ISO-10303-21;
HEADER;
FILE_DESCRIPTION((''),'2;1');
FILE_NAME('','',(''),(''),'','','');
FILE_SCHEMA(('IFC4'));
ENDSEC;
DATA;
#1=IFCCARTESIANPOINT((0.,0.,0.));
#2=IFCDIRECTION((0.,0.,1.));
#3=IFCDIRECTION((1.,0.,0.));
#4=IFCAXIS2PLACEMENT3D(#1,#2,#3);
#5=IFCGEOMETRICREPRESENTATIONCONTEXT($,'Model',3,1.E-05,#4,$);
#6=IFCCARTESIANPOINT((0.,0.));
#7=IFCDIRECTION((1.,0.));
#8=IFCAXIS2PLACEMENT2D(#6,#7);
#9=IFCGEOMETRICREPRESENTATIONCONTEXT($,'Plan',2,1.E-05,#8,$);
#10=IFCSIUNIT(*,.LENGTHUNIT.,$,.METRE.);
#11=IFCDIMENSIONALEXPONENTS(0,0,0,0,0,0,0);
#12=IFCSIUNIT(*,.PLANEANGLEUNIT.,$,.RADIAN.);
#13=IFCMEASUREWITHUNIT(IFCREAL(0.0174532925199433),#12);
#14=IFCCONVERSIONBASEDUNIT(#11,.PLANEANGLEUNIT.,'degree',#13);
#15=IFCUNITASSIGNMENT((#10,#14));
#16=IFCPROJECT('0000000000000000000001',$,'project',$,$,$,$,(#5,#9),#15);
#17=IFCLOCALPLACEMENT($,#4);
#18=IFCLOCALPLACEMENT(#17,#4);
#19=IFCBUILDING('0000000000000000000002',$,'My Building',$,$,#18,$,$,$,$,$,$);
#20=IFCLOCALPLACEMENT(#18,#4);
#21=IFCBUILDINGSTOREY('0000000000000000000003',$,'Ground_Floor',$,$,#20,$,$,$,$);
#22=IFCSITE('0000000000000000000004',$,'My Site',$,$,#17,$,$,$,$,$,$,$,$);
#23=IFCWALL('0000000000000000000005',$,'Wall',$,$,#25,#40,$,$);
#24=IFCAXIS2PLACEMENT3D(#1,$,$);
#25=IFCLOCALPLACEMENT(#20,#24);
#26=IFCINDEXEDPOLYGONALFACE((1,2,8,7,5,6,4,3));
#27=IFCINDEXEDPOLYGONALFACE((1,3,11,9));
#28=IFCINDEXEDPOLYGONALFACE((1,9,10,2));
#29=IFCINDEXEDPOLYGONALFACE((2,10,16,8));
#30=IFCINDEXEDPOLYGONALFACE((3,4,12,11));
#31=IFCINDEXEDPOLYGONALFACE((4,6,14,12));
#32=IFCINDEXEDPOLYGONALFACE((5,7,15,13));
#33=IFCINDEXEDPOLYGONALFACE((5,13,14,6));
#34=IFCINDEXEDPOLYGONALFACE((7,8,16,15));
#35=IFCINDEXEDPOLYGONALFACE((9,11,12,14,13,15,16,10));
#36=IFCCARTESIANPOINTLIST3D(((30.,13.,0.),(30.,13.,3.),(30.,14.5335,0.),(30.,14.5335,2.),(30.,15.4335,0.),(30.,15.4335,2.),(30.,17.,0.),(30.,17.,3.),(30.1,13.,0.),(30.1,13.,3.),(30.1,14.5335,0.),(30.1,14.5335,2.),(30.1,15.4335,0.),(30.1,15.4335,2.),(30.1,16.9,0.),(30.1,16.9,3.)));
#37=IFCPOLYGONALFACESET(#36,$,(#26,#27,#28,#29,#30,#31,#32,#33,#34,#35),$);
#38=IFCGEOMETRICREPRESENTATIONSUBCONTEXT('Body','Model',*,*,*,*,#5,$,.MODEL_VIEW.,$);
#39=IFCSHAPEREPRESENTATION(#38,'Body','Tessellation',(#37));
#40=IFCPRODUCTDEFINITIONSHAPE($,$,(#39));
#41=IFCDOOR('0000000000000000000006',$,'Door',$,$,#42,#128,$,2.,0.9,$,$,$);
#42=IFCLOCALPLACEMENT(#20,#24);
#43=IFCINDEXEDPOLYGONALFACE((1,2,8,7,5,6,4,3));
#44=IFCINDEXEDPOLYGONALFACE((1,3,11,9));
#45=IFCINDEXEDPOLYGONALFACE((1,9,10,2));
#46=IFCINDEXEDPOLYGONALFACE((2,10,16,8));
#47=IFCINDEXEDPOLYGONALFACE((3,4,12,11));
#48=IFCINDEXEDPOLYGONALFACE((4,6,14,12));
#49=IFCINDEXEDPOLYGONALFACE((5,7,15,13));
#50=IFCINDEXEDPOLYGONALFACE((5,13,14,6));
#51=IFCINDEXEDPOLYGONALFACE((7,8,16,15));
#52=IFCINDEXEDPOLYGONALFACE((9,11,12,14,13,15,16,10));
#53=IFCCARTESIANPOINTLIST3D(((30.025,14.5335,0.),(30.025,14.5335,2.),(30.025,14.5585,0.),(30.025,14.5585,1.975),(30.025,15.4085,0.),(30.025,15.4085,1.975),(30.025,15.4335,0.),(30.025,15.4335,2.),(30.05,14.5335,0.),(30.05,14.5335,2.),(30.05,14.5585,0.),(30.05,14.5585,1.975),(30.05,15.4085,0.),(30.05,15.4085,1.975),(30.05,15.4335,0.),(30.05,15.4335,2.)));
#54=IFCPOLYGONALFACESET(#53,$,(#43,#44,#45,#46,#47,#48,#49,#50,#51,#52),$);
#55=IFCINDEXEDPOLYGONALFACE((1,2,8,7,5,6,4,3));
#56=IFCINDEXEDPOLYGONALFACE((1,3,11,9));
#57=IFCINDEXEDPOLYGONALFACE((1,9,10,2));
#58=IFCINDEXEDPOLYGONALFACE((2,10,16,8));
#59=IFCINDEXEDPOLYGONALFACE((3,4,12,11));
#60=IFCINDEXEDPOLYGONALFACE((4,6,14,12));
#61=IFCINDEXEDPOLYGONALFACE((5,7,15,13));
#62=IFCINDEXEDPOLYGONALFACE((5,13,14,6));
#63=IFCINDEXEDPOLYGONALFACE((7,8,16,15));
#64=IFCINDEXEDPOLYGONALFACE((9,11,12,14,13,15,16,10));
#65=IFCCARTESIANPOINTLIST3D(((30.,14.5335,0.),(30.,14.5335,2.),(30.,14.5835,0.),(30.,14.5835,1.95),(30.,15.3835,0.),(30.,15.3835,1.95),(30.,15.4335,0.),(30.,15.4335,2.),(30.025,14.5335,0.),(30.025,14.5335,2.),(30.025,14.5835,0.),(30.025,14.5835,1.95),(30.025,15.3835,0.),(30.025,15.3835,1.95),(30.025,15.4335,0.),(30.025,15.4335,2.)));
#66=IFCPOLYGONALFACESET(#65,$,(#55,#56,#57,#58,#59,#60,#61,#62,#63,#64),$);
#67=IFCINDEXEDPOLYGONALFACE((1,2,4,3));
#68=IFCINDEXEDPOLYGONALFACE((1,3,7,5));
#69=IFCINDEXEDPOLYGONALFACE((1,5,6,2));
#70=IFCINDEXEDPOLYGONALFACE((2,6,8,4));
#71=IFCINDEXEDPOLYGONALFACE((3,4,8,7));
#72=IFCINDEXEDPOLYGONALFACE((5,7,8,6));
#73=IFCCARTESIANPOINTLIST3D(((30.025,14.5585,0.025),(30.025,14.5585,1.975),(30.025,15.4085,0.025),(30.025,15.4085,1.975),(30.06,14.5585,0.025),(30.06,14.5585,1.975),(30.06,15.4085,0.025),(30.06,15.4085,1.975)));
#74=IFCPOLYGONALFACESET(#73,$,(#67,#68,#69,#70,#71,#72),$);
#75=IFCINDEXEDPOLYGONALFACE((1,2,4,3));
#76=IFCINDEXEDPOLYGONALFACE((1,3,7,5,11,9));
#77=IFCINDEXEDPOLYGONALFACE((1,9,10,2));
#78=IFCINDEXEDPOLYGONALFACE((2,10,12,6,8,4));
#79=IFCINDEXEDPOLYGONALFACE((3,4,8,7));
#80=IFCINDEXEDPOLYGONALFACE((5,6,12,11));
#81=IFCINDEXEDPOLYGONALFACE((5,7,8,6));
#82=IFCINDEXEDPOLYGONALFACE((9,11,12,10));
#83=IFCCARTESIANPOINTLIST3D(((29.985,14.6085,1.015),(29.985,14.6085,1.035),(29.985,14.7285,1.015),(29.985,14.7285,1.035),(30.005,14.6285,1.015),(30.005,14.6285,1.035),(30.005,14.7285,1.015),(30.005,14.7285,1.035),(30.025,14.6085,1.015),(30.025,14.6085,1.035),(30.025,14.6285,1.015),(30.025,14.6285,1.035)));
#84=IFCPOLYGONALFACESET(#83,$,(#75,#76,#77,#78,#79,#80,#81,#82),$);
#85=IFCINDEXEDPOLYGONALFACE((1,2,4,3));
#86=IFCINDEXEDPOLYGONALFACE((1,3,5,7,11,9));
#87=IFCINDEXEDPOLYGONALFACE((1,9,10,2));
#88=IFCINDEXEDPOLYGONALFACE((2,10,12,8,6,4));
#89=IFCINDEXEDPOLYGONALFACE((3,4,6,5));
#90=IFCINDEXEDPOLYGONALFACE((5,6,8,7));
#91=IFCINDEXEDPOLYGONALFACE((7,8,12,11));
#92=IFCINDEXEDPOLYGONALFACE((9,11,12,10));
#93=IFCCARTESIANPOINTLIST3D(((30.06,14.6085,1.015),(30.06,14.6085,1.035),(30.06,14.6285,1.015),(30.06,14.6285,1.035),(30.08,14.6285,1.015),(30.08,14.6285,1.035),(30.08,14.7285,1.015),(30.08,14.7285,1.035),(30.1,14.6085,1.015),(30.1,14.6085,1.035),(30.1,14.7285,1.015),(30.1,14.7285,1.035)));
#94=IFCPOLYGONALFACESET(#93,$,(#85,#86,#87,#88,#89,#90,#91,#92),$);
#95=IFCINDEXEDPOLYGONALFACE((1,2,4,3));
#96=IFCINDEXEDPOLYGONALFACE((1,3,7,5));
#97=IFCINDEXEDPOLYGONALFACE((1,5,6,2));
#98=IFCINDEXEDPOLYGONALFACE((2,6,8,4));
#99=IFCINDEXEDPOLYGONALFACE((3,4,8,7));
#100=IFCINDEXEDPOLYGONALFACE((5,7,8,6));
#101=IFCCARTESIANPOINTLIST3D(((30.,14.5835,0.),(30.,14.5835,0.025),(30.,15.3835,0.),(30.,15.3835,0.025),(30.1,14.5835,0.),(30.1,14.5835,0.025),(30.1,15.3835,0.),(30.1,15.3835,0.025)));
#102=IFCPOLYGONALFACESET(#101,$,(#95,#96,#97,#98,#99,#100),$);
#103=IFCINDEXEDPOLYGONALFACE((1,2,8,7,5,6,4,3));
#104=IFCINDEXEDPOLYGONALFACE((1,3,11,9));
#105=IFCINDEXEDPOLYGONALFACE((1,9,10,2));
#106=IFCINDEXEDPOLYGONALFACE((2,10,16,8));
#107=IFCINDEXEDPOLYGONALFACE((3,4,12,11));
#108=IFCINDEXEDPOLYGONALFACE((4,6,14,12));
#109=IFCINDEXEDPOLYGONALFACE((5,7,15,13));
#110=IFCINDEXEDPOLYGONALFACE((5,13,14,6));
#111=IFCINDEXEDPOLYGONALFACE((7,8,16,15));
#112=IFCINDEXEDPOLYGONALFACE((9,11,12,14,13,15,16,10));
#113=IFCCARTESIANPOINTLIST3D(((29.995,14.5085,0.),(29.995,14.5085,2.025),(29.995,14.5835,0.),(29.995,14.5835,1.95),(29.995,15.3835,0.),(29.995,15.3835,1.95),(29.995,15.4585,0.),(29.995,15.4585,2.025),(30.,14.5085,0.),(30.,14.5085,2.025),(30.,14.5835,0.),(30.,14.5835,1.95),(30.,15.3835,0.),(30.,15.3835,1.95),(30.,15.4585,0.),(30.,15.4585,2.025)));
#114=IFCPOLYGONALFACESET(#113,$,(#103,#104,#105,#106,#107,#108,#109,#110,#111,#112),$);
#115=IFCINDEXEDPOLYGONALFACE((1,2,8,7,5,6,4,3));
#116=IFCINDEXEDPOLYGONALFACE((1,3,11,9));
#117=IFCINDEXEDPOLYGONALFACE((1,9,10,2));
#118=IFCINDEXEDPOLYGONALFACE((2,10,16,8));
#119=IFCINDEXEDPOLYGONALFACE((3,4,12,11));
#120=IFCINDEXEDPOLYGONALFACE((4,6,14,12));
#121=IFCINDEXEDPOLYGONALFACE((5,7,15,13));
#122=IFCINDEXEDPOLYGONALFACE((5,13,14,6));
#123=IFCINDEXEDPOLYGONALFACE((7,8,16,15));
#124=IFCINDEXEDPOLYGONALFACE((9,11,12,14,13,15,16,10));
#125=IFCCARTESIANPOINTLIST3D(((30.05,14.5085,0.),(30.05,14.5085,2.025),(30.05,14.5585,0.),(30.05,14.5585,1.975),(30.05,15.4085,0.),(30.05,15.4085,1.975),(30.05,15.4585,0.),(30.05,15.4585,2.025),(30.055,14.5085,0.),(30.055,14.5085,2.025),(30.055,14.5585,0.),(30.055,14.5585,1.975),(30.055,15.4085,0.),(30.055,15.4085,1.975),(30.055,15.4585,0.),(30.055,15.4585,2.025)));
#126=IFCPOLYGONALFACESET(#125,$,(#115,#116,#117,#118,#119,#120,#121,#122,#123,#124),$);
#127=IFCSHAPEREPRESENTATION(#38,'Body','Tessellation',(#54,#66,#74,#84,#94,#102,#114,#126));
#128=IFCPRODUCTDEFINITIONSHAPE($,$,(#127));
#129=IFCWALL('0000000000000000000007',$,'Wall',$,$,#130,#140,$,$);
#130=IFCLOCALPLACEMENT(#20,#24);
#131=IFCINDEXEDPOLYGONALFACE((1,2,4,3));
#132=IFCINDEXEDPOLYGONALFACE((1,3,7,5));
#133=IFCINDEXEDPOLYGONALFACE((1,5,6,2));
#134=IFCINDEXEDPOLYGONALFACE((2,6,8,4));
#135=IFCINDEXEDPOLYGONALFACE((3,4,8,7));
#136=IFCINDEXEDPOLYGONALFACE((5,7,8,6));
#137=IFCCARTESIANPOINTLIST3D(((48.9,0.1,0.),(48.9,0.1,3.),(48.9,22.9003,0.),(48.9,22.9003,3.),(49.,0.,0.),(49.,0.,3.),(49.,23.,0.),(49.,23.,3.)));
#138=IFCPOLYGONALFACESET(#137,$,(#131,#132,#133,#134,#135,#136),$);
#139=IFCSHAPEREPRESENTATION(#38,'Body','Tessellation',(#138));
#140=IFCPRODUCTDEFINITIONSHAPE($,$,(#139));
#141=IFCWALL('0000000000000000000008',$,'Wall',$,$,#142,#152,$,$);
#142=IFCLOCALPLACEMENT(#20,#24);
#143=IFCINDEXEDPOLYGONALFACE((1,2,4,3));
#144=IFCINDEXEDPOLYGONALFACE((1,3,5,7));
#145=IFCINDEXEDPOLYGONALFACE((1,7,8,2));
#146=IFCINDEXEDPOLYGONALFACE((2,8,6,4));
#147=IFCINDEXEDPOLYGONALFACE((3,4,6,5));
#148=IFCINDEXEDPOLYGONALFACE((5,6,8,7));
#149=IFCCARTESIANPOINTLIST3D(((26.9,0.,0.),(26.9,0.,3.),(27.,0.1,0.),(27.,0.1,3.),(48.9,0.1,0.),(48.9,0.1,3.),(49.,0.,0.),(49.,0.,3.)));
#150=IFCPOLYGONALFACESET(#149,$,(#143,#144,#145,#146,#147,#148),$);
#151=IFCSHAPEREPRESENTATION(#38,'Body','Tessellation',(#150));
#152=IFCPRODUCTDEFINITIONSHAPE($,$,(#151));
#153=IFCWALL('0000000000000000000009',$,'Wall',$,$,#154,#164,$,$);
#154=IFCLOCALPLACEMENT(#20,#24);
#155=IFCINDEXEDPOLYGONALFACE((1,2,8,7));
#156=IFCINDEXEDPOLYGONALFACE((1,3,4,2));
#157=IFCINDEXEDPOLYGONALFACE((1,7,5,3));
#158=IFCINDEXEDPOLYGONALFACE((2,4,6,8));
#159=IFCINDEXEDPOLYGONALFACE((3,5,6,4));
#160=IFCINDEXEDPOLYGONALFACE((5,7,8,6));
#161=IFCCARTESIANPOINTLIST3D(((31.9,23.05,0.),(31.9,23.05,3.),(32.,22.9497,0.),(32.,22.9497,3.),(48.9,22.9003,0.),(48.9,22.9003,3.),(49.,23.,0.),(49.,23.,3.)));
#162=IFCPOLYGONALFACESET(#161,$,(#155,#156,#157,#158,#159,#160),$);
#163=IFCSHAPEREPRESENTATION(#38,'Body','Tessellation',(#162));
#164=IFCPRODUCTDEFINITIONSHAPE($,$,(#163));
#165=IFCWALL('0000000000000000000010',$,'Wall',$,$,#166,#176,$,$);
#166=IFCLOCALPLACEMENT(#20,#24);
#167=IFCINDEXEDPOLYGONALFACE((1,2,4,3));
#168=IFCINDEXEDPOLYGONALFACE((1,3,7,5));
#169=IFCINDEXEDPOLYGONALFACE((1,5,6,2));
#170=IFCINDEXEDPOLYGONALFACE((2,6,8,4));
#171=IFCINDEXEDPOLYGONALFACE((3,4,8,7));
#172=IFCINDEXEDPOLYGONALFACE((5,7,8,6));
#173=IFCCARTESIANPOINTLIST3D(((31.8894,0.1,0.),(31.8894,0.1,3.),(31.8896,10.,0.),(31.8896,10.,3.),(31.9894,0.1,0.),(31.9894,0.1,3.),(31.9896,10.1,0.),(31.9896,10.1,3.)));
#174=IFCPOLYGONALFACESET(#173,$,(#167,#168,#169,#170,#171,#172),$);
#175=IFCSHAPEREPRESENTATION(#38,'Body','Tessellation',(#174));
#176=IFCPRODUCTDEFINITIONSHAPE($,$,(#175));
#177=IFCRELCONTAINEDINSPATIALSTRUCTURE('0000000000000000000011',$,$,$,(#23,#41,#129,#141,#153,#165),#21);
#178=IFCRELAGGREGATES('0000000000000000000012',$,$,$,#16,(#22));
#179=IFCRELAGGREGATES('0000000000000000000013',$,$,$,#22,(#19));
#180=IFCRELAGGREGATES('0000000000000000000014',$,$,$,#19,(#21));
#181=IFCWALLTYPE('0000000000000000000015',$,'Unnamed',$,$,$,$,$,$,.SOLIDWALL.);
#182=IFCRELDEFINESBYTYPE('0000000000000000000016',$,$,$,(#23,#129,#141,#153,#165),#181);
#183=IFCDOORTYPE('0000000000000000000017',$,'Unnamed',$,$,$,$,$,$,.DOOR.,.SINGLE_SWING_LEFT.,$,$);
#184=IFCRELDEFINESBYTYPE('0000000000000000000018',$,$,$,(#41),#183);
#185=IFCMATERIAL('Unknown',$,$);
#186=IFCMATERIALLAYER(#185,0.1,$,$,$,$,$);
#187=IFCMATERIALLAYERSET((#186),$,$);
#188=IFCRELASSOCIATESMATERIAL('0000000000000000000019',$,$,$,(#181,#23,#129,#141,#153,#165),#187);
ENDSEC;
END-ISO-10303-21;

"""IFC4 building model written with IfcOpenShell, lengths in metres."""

from ifc_helpers import new_model, entity, si_unit, converted_unit, frame, origin_with_axes, origin_2d_with_axis, place, context, subcontext, project, spatial, line, indexed_curve, outline, extrude, shape, source, transform, mapped, material, layer, layer_set, layer_usage, type_object, type_shapes, element, fill, save


model = new_model("IFC4")

# Units and contexts
model_context = context("Model", 3, precision=1e-05, world=origin_with_axes())
plan_context = context("Plan", 2, precision=1e-05, world=origin_2d_with_axis())
body_context_1 = subcontext(model_context, "Body", "Model", "MODEL_VIEW")
body_context_2 = subcontext(plan_context, "Body", "Plan", "PLAN_VIEW")
ifc_project = project(units=[si_unit("LENGTHUNIT", "METRE"), converted_unit("PLANEANGLEUNIT", "degree", entity("IfcReal", 0.0174532925199433), si_unit("PLANEANGLEUNIT", "RADIAN"), dimensions=[0, 0, 0, 0, 0, 0, 0])], contexts=[model_context, plan_context])

# Site, building, storey
site_placement = place(None, origin_with_axes())
site = spatial("IfcSite", under=ifc_project, at=site_placement, Name="My Site")
building_placement = place(site_placement, origin_with_axes())
building = spatial("IfcBuilding", under=site, at=building_placement, Name="My Building")
storey_placement = place(building_placement, origin_with_axes())
storey = spatial("IfcBuildingStorey", under=building, at=storey_placement, Name="Ground_Floor")

# Shared definitions
ifc_material = material(Name="Unknown")
ifc_layer = layer(ifc_material, 0.1)
ifc_layer_set = layer_set([ifc_layer])
wall_type = type_object("IfcWallType", Name="Unnamed", PredefinedType="SOLIDWALL", material=ifc_layer_set)

# Shared definitions
shared_shape_1 = source(origin_with_axes(), body_context_1, "Body", "SweptSolid", [
    extrude(outline(indexed_curve([(0.0, 0.0), (0.9, 0.0), (0.9, 2.0), (0.0, 2.0)], segments=[line(1, 2, 3, 4, 1)])), frame((0.0, -0.6, 0.0), z_axis=(0.0, -1.0, 0.0), x_axis=(1.0, 0.0, 0.0)), (0.0, 0.0, -1.0), 1.2),
])
door_type_1 = type_object("IfcDoorType", Name="Unnamed", OperationType="SINGLE_SWING_LEFT", PredefinedType="DOOR")
shared_shape_2 = source(origin_with_axes(), body_context_1, "Body", "SweptSolid", [
    extrude(outline(indexed_curve([(0.0, 0.0), (0.0, 2.0), (0.9, 2.0), (0.9, 0.0), (0.875, 0.0), (0.875, 1.975), (0.025, 1.975), (0.025, 0.0)], segments=[line(1, 2, 3, 4, 5, 6, 7, 8, 1)])), frame((0.0, 0.025, 0.0), z_axis=(0.0, -1.0, 0.0), x_axis=(1.0, 0.0, 0.0)), (0.0, 0.0, -1.0), 0.025),
    extrude(outline(indexed_curve([(0.0, 0.0), (0.0, 2.0), (0.9, 2.0), (0.9, 0.0), (0.85, 0.0), (0.85, 1.95), (0.05, 1.95), (0.05, 0.0)], segments=[line(1, 2, 3, 4, 5, 6, 7, 8, 1)])), frame((0.0, 0.0, 0.0), z_axis=(0.0, -1.0, 0.0), x_axis=(1.0, 0.0, 0.0)), (0.0, 0.0, -1.0), 0.025),
    extrude(outline(indexed_curve([(0.0, 0.0), (0.85, 0.0), (0.85, 0.035), (0.0, 0.035)], segments=[line(1, 2, 3, 4, 1)])), frame((0.025, 0.025, 0.025), z_axis=(0.0, 0.0, 1.0), x_axis=(1.0, 0.0, 0.0)), (0.0, 0.0, 1.0), 1.95),
    extrude(outline(indexed_curve([(0.0, 0.0), (0.0, -0.04), (-0.12, -0.04), (-0.12, -0.02), (-0.02, -0.02), (-0.02, 0.0)], segments=[line(1, 2, 3, 4, 5, 6, 1)])), frame((0.825, 0.025, 1.015), z_axis=(0.0, 0.0, 1.0), x_axis=(1.0, 0.0, 0.0)), (0.0, 0.0, 1.0), 0.02),
    extrude(outline(indexed_curve([(0.0, 0.0), (0.0, 0.04), (-0.12, 0.04), (-0.12, 0.02), (-0.02, 0.02), (-0.02, 0.0)], segments=[line(1, 2, 3, 4, 5, 6, 1)])), frame((0.825, 0.06, 1.015), z_axis=(0.0, 0.0, 1.0), x_axis=(1.0, 0.0, 0.0)), (0.0, 0.0, 1.0), 0.02),
    extrude(outline(indexed_curve([(0.0, 0.0), (0.8, 0.0), (0.8, 0.1), (0.0, 0.1)], segments=[line(1, 2, 3, 4, 1)])), frame((0.05, 0.0, 0.0), z_axis=(0.0, 0.0, 1.0), x_axis=(1.0, 0.0, 0.0)), (0.0, 0.0, 1.0), 0.025),
    extrude(outline(indexed_curve([(0.0, 0.0), (0.0, 2.025), (0.95, 2.025), (0.95, 0.0), (0.875, 0.0), (0.875, 1.95), (0.075, 1.95), (0.075, 0.0)], segments=[line(1, 2, 3, 4, 5, 6, 7, 8, 1)])), frame((-0.025, -0.005, 0.0), z_axis=(0.0, -1.0, 0.0), x_axis=(1.0, 0.0, 0.0)), (0.0, 0.0, -1.0), 0.005),
    extrude(outline(indexed_curve([(0.0, 0.0), (0.0, 2.025), (0.95, 2.025), (0.95, 0.0), (0.9, 0.0), (0.9, 1.975), (0.05, 1.975), (0.05, 0.0)], segments=[line(1, 2, 3, 4, 5, 6, 7, 8, 1)])), frame((-0.025, 0.05, 0.0), z_axis=(0.0, -1.0, 0.0), x_axis=(1.0, 0.0, 0.0)), (0.0, 0.0, -1.0), 0.005),
])
shared_shape_3 = source(origin_with_axes(), body_context_2, "Body", "Curve2D", [
    entity("IfcIndexedPolyCurve", entity("IfcCartesianPointList2D", [[0.0, 0.0], [0.0, 0.05], [0.025, 0.05], [0.025, 0.025], [0.05, 0.025], [0.05, 0.0]]), [entity("IfcLineIndex", [1, 2, 3, 4, 5, 6, 1])]),
    entity("IfcIndexedPolyCurve", entity("IfcCartesianPointList2D", [[0.9, 0.0], [0.9, 0.05], [0.875, 0.05], [0.875, 0.025], [0.85, 0.025], [0.85, 0.0]]), [entity("IfcLineIndex", [1, 2, 3, 4, 5, 6, 1])]),
    entity("IfcTrimmedCurve", entity("IfcEllipse", entity("IfcAxis2Placement2D", entity("IfcCartesianPoint", [0.06, 0.05]), entity("IfcDirection", [1.0, 0.0])), 0.815, 0.85), [entity("IfcCartesianPoint", [0.875, 0.05])], [entity("IfcCartesianPoint", [0.06, 0.9])], True, "CARTESIAN"),
    entity("IfcIndexedPolyCurve", entity("IfcCartesianPointList2D", [[0.025, 0.05], [0.06, 0.05], [0.06, 0.9], [0.025, 0.9]]), [entity("IfcLineIndex", [1, 2, 3, 4, 1])]),
])
type_shapes(door_type_1, [shared_shape_2, shared_shape_3])

# Wall, opening, door
ifc_layer_usage_1 = layer_usage(ifc_layer_set, "AXIS2", "POSITIVE", 0.0)
wall_1_placement = place(storey_placement, frame((30.0, 17.0, 0.0), z_axis=(0.0, 0.0, 1.0), x_axis=(0.0, -1.0, 0.0)))
wall_1 = element("IfcWall", 1, at=wall_1_placement, inside=storey, type_object=wall_type, material=ifc_layer_usage_1, Name="Wall", context=body_context_1, shape_type="SweptSolid", body=[
    extrude(outline(indexed_curve([(0.0, 0.0), (0.1, 0.1), (4.0, 0.1), (4.0, 0.0)], segments=[line(1, 2, 3, 4, 1)])), origin_with_axes(), (0.0, 0.0, 1.0), 3.0),
])
opening_1_placement = place(wall_1_placement, frame((1.5665, 0.0, 0.0), z_axis=(0.0, 0.0, 1.0), x_axis=(1.0, 0.0, 0.0)))
opening_1 = element("IfcOpeningElement", 2, at=opening_1_placement, cuts=wall_1, PredefinedType="OPENING", context=body_context_1, shape_type="MappedRepresentation", body=[
    mapped(shared_shape_1, transform((0.0, 0.0, 0.0), x_axis=(1.0, 0.0, 0.0), y_axis=(0.0, 1.0, 0.0), z_axis=(0.0, 0.0, 1.0), scale=1.0)),
])
door_1_placement = place(opening_1_placement, origin_with_axes())
door_1 = element("IfcDoor", 3, at=door_1_placement, inside=storey, type_object=door_type_1, Name="Door", OverallHeight=2.0, OverallWidth=0.9, shapes=[
    shape(body_context_1, "Body", "MappedRepresentation", [mapped(shared_shape_2, transform((0.0, 0.0, 0.0), x_axis=(1.0, 0.0, 0.0), y_axis=(0.0, 1.0, 0.0), z_axis=(0.0, 0.0, 1.0), scale=1.0))]),
    shape(body_context_2, "Body", "MappedRepresentation", [mapped(shared_shape_3, transform((0.0, 0.0, 0.0), x_axis=(1.0, 0.0, 0.0), y_axis=(0.0, 1.0, 0.0), z_axis=(0.0, 0.0, 1.0), scale=1.0))]),
])
fill(opening_1, door_1)

# Walls
ifc_layer_usage_2 = layer_usage(ifc_layer_set, "AXIS2", "POSITIVE", 0.0)
wall_2_placement = place(storey_placement, frame((49.0, 0.0, 0.0), z_axis=(0.0, 0.0, 1.0), x_axis=(0.0, 1.0, 0.0)))
element("IfcWall", 4, at=wall_2_placement, inside=storey, type_object=wall_type, material=ifc_layer_usage_2, Name="Wall", context=body_context_1, shape_type="SweptSolid", body=[
    extrude(outline(indexed_curve([(0.0, 0.0), (0.1, 0.1), (22.9003, 0.1), (23.0, 0.0)], segments=[line(1, 2, 3, 4, 1)])), origin_with_axes(), (0.0, 0.0, 1.0), 3.0),
])
ifc_layer_usage_3 = layer_usage(ifc_layer_set, "AXIS2", "POSITIVE", 0.0)
wall_3_placement = place(storey_placement, frame((27.0, 0.0, 0.0), z_axis=(0.0, 0.0, 1.0), x_axis=(1.0, 0.0, 0.0)))
element("IfcWall", 5, at=wall_3_placement, inside=storey, type_object=wall_type, material=ifc_layer_usage_3, Name="Wall", context=body_context_1, shape_type="SweptSolid", body=[
    extrude(outline(indexed_curve([(-0.1, 0.0), (0.0, 0.1), (21.9, 0.1), (22.0, 0.0)], segments=[line(1, 2, 3, 4, 1)])), origin_with_axes(), (0.0, 0.0, 1.0), 3.0),
])
ifc_layer_usage_4 = layer_usage(ifc_layer_set, "AXIS2", "POSITIVE", 0.0)
wall_4_placement = place(storey_placement, frame((32.0, 22.9497, 0.0), z_axis=(0.0, 0.0, 1.0), x_axis=(0.999996, -0.002924, 0.0)))
element("IfcWall", 6, at=wall_4_placement, inside=storey, type_object=wall_type, material=ifc_layer_usage_4, Name="Wall", context=body_context_1, shape_type="SweptSolid", body=[
    extrude(outline(indexed_curve([(0.0, 0.0), (-0.1003, 0.1), (16.9998, 0.1), (16.9001, 0.0)], segments=[line(1, 2, 3, 4, 1)])), origin_with_axes(), (0.0, 0.0, 1.0), 3.0),
])
ifc_layer_usage_5 = layer_usage(ifc_layer_set, "AXIS2", "POSITIVE", 0.0)
wall_5_placement = place(storey_placement, frame((31.8896, 10.0, 0.0), z_axis=(0.0, 0.0, 1.0), x_axis=(-0.000027, -1.0, 0.0)))
element("IfcWall", 7, at=wall_5_placement, inside=storey, type_object=wall_type, material=ifc_layer_usage_5, Name="Wall", context=body_context_1, shape_type="SweptSolid", body=[
    extrude(outline(indexed_curve([(0.0, 0.0), (-0.1, 0.1), (9.9, 0.1), (9.9, 0.0)], segments=[line(1, 2, 3, 4, 1)])), origin_with_axes(), (0.0, 0.0, 1.0), 3.0),
])

save(model, "model.ifc")
